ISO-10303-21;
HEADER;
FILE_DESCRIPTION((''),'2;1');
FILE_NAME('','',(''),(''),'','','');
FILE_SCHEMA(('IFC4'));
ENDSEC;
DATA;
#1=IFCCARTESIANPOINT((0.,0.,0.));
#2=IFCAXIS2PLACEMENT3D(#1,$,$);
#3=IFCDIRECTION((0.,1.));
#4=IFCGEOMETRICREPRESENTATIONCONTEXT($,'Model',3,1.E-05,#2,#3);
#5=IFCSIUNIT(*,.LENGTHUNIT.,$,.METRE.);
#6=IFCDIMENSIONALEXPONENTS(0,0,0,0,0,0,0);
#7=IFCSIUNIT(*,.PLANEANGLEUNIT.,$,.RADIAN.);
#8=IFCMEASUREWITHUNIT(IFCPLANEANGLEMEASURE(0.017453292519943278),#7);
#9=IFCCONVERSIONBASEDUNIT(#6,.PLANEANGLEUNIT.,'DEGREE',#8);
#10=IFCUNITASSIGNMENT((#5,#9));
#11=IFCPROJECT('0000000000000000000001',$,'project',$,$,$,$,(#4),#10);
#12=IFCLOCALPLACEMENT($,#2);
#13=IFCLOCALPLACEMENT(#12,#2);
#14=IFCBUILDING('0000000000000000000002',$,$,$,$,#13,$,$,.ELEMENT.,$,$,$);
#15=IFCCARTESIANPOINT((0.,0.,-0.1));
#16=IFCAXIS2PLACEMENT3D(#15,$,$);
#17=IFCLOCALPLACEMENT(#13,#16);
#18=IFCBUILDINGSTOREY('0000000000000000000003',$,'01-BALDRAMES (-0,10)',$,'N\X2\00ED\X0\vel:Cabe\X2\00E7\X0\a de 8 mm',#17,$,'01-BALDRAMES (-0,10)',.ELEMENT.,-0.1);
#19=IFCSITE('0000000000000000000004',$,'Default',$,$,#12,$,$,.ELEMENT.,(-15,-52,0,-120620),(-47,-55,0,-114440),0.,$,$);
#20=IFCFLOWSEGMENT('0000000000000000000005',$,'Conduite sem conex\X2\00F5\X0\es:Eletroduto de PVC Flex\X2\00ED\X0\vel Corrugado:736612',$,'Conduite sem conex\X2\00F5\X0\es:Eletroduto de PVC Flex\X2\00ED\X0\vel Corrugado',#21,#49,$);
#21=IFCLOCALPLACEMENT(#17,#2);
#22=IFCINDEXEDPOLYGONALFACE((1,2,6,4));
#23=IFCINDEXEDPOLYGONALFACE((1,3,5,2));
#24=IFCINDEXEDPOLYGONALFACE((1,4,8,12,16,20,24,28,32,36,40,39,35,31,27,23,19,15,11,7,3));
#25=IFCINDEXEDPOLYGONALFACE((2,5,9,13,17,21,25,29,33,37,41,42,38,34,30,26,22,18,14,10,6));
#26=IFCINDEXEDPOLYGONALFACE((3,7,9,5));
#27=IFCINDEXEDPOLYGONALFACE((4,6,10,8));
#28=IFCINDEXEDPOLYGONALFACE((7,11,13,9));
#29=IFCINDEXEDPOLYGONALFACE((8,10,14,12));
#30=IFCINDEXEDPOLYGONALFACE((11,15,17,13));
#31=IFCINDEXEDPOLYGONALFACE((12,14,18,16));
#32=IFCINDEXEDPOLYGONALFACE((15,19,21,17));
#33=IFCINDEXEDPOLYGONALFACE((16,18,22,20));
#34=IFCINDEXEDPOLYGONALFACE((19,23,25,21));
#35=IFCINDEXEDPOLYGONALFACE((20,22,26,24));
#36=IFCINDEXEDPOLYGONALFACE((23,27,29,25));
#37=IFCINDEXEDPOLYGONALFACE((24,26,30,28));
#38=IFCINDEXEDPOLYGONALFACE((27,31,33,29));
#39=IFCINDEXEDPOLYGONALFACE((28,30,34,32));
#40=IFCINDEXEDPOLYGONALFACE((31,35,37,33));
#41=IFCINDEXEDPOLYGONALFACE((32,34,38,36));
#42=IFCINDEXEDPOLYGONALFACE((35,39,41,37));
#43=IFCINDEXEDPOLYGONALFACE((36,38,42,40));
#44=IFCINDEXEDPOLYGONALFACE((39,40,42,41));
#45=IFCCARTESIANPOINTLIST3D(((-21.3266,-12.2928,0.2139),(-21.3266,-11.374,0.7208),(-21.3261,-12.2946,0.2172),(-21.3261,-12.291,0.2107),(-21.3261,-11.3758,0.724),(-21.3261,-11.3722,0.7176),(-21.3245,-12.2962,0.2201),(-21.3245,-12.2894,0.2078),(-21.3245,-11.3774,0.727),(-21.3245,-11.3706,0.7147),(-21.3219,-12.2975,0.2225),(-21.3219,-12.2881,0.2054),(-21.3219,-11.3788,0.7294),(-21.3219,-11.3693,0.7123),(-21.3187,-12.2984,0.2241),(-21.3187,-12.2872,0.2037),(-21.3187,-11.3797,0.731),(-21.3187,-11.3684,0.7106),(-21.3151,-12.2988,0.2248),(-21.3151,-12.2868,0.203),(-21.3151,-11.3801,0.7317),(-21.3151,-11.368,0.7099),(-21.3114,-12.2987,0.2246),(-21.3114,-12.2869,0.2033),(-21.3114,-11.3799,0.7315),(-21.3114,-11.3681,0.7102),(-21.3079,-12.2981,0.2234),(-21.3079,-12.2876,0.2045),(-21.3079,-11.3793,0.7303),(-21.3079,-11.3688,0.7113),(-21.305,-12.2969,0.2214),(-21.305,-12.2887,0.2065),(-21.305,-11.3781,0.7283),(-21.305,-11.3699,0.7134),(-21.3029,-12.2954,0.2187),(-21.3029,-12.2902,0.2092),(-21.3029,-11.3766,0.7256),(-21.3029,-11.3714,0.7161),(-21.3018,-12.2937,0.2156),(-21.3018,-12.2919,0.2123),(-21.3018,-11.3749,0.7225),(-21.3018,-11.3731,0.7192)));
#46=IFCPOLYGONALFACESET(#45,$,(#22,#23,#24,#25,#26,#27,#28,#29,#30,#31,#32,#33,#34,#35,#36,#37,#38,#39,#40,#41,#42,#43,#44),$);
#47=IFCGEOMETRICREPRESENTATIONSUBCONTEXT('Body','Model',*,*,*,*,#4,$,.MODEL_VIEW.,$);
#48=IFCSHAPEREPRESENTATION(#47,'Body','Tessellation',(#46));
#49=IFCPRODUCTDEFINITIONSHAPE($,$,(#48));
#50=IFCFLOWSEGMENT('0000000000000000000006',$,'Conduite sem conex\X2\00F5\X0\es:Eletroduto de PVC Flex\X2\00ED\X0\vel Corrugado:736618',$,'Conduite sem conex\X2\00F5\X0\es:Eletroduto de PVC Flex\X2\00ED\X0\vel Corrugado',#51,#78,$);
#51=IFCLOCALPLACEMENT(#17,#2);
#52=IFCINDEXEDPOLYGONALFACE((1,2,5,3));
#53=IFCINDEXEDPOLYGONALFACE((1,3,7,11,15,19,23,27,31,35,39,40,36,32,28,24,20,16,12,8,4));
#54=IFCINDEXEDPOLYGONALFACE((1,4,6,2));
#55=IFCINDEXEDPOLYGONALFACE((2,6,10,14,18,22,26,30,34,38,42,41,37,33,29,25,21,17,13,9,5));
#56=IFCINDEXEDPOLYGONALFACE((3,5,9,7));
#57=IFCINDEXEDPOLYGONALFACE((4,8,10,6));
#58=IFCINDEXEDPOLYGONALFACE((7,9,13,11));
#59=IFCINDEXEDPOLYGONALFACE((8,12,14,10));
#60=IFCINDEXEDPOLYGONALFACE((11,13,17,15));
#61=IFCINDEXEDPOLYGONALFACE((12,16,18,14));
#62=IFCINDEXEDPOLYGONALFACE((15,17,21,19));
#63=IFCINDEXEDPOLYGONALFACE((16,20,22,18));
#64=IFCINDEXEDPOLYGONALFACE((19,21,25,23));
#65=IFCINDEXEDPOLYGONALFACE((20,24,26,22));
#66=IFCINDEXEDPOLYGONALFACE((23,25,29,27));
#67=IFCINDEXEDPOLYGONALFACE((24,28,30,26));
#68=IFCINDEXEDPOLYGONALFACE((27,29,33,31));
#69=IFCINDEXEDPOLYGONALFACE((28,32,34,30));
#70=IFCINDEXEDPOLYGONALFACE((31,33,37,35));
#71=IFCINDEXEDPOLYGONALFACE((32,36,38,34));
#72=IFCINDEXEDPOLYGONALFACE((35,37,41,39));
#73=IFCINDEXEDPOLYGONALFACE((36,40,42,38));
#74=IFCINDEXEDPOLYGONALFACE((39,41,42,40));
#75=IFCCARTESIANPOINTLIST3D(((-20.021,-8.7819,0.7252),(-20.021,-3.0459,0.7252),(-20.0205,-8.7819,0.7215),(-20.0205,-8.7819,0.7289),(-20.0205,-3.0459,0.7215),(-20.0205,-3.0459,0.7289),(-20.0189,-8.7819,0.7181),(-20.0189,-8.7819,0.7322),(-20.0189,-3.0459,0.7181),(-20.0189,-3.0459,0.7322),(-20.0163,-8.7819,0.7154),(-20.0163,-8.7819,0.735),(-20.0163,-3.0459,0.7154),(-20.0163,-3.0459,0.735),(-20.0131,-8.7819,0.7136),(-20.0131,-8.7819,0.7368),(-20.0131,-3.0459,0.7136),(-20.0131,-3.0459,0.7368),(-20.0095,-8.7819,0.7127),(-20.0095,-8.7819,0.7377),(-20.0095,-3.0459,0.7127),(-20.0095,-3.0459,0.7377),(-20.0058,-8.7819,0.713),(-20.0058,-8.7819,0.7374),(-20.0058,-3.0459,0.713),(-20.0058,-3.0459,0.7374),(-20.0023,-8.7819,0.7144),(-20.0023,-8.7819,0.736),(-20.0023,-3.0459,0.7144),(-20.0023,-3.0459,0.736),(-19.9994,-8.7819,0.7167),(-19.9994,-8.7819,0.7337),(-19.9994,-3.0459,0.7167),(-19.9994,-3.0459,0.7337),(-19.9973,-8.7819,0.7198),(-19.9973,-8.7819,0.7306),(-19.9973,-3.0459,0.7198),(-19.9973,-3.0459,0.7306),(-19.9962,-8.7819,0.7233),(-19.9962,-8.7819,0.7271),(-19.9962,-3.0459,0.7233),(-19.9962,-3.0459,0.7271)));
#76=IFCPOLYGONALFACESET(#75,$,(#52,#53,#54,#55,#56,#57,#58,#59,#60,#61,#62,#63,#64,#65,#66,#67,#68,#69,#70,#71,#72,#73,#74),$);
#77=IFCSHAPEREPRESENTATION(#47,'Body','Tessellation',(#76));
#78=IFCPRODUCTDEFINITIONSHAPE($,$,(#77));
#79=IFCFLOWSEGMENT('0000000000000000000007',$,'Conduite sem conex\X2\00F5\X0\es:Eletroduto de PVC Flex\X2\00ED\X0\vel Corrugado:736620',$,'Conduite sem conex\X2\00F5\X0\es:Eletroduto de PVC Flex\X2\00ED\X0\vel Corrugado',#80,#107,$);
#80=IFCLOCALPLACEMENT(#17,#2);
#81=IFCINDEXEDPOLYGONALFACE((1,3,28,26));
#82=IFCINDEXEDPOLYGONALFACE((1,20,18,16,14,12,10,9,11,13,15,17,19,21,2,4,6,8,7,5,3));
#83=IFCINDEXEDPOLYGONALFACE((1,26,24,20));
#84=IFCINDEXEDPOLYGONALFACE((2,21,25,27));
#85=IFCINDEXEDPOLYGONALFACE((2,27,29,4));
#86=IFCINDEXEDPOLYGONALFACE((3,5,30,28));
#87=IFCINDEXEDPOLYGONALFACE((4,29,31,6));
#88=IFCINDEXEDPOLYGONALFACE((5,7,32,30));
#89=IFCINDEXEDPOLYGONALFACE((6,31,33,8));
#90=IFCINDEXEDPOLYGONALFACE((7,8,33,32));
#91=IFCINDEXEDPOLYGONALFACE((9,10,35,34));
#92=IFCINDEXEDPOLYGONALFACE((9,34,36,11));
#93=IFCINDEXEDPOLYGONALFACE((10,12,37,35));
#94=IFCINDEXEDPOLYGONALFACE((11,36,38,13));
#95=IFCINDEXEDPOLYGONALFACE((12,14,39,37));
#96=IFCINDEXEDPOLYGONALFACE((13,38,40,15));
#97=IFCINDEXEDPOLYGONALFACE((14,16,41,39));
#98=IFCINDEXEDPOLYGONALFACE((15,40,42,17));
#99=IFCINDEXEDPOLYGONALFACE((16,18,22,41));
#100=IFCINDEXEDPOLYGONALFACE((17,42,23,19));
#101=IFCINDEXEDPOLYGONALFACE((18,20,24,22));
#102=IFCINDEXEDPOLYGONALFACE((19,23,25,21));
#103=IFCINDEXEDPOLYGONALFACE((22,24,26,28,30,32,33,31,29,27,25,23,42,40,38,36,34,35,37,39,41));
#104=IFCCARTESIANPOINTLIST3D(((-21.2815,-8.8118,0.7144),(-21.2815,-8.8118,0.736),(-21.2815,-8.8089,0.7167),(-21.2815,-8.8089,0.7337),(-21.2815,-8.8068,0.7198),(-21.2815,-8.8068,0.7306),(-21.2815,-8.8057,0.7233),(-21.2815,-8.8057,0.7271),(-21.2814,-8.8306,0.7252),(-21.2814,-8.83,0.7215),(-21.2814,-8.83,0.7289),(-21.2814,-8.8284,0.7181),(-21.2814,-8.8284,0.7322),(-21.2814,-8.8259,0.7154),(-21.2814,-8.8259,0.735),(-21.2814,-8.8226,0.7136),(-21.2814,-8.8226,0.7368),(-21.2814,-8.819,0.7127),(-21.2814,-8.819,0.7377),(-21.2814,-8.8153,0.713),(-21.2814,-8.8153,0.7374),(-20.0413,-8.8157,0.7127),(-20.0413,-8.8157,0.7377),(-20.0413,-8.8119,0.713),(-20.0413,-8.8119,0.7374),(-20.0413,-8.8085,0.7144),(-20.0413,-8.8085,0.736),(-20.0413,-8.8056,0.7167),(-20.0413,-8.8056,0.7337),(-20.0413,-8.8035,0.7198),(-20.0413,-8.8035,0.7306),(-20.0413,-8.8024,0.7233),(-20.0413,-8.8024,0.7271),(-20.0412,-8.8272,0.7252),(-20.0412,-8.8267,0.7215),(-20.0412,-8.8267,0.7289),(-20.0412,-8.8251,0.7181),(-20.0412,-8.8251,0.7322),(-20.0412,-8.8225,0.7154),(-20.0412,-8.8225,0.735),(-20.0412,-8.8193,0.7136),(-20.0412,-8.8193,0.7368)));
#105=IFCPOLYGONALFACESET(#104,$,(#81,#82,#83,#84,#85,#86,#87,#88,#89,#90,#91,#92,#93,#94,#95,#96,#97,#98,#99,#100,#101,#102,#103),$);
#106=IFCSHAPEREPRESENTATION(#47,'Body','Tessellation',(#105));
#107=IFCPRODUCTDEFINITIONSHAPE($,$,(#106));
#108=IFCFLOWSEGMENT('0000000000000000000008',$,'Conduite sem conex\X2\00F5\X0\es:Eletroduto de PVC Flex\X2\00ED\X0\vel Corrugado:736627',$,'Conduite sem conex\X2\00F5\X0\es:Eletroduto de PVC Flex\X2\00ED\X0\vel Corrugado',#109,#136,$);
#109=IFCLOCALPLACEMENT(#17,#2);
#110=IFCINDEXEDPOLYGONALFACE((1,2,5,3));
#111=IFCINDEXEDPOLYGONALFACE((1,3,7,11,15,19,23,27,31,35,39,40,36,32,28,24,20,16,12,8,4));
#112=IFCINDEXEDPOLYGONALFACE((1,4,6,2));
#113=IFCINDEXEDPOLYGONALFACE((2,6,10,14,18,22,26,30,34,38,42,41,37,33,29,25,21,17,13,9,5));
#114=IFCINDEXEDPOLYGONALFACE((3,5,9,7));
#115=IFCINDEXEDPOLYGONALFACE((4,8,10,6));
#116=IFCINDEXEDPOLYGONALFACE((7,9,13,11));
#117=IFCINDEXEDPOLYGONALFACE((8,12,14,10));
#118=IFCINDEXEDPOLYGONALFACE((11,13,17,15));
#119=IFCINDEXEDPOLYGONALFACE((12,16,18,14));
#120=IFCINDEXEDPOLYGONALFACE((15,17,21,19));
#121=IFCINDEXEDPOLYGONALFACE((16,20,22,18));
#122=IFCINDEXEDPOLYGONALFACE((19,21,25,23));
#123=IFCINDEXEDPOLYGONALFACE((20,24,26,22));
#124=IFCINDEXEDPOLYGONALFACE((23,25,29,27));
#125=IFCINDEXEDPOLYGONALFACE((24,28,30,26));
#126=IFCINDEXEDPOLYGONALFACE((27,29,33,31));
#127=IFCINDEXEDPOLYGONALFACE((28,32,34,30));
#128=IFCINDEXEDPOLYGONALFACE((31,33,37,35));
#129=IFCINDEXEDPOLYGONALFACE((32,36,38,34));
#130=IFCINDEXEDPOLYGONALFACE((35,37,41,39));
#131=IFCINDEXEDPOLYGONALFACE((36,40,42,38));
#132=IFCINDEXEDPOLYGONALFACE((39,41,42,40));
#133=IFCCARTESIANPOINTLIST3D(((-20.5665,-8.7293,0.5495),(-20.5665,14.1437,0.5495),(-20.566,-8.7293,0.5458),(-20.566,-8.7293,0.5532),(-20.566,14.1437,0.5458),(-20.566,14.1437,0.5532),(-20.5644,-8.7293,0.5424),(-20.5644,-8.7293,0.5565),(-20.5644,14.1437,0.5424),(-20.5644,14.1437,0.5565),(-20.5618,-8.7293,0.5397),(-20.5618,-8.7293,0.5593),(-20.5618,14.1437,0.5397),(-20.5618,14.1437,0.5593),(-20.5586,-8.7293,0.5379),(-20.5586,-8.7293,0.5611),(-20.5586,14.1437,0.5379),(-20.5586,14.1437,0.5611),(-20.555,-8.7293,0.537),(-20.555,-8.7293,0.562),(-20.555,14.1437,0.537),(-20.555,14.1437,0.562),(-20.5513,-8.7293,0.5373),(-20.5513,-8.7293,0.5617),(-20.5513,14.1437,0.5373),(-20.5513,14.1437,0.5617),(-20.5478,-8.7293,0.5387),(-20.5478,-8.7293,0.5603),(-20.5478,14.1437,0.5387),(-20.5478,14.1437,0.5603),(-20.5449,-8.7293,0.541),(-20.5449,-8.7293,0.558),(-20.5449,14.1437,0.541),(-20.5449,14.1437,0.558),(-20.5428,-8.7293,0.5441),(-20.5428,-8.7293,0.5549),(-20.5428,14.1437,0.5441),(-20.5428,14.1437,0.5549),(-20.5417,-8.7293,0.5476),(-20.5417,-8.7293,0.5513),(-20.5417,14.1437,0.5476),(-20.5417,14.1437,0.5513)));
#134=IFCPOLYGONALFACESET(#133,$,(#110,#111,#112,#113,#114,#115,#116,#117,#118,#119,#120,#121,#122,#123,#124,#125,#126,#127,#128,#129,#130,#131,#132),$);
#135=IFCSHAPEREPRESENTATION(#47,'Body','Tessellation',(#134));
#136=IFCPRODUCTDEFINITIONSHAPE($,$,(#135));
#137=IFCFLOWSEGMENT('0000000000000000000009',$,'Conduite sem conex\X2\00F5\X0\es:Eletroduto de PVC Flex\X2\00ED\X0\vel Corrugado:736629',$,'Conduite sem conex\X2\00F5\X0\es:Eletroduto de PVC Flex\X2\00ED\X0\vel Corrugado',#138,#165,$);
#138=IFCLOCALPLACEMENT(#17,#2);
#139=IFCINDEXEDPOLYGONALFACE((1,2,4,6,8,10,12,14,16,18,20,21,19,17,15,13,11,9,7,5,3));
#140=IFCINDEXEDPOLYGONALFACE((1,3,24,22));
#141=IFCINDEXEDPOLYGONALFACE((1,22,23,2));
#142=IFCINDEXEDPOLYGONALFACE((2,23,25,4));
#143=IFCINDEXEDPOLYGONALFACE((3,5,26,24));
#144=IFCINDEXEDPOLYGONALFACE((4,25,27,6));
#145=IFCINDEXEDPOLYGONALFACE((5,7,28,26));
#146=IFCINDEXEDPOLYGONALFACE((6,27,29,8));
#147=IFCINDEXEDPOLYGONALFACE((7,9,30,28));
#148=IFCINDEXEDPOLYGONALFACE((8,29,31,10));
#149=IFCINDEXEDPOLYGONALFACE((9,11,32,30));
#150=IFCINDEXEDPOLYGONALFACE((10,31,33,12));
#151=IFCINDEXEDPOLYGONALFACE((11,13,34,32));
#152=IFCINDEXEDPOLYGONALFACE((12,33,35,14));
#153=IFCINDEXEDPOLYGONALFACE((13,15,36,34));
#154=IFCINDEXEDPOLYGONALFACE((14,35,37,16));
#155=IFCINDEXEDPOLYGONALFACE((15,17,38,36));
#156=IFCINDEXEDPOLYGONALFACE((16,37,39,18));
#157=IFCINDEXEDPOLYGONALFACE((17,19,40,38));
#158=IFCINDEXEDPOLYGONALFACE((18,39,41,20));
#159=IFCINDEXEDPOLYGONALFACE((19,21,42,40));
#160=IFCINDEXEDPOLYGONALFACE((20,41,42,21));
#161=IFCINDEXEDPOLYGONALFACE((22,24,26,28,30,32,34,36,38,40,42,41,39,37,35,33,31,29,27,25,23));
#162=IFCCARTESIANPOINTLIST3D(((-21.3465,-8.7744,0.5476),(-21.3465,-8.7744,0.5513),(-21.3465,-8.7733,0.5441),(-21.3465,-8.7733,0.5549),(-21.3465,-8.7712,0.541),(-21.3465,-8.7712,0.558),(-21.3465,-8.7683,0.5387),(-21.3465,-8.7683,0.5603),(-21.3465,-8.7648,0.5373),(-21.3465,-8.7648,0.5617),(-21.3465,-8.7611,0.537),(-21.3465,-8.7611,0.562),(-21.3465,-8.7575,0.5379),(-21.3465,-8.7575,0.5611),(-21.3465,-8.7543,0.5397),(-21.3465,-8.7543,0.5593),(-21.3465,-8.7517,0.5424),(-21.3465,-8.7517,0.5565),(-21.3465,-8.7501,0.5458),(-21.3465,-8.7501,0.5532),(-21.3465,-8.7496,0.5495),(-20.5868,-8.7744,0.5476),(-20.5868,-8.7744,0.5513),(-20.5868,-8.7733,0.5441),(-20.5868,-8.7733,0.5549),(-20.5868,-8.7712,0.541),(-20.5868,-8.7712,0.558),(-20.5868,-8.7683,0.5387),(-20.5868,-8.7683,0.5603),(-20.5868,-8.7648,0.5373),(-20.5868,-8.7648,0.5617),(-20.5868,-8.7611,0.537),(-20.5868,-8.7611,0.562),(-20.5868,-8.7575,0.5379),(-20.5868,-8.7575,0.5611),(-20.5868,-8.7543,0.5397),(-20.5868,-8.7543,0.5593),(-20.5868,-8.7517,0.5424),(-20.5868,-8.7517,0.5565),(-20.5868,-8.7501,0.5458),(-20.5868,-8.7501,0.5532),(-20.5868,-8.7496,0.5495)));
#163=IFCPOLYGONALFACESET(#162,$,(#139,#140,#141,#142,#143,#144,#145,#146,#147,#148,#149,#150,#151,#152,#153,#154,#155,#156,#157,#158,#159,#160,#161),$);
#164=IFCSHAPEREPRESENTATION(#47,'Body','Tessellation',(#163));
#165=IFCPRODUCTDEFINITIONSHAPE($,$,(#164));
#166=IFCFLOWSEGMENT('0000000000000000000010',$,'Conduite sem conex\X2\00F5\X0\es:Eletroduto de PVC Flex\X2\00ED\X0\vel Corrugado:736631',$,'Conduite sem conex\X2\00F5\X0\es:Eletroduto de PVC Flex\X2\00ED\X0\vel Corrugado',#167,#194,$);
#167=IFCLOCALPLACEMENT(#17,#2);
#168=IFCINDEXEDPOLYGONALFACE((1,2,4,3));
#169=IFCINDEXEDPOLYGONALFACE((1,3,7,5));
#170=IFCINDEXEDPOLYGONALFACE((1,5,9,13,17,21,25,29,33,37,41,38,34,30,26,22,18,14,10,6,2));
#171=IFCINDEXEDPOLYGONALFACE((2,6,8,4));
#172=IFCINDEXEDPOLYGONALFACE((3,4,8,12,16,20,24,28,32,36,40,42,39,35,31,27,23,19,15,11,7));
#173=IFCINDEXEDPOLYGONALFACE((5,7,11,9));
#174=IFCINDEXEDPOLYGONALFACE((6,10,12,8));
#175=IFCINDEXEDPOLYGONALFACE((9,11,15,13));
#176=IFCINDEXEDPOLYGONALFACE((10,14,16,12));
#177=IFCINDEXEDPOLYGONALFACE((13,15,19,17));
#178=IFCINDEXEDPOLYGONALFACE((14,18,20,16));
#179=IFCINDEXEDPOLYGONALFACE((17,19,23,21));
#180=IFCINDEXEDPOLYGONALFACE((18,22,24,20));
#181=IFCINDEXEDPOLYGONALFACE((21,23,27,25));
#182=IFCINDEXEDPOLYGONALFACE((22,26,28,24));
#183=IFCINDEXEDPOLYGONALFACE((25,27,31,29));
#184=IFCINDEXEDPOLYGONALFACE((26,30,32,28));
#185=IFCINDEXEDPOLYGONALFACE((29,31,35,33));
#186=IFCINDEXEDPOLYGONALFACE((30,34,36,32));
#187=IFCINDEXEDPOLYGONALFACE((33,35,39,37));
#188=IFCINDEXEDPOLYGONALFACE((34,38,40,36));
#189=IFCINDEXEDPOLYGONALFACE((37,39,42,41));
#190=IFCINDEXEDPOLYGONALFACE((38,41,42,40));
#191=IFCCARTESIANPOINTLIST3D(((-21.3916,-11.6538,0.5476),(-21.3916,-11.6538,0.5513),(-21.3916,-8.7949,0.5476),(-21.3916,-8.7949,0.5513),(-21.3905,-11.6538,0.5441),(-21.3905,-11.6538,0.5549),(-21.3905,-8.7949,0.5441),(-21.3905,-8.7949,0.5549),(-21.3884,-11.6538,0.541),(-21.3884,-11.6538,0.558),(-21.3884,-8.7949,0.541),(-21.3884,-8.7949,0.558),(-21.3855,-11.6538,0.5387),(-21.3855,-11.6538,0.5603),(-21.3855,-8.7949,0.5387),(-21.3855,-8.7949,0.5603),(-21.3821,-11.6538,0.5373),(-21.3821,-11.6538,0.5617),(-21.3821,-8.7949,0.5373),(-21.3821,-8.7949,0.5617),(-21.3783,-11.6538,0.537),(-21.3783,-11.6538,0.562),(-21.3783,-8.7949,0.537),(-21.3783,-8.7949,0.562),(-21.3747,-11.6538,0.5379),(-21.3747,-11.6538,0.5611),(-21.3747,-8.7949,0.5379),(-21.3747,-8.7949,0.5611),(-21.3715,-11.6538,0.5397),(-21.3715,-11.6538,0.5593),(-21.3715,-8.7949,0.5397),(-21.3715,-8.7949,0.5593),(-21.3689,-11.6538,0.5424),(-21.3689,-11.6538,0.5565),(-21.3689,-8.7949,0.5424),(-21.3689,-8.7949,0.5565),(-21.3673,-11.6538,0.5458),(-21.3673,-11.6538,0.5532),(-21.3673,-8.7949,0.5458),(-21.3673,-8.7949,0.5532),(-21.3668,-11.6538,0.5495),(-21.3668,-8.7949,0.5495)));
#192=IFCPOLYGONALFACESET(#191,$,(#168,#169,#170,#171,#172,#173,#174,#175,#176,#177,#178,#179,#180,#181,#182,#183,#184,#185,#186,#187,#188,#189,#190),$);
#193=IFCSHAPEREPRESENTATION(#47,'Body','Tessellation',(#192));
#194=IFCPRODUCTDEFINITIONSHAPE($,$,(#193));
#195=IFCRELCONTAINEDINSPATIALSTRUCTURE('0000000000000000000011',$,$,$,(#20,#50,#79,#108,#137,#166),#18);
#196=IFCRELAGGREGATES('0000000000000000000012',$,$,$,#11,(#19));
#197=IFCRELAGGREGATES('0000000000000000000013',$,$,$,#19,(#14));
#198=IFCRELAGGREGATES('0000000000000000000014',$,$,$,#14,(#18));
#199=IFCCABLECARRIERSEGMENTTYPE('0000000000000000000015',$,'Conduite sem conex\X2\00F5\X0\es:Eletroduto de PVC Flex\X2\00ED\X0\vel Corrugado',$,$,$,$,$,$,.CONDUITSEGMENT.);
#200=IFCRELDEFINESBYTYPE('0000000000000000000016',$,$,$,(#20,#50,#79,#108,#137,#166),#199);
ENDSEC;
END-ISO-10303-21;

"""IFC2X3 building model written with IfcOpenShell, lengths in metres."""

from ifc_helpers import new_model, entity, si_unit, converted_unit, direction, frame, frame_2d, origin, origin_2d_with_axis, place, context, subcontext, project, spatial, circle, extrude, type_object, element, save


model = new_model("IFC2X3")

# Units and contexts
model_context = context("Model", 3, precision=1e-05, world=origin(), true_north=direction((0.0, 1.0)))
body_context = subcontext(model_context, "Body", "Model", "MODEL_VIEW")
ifc_project = project(units=[si_unit("LENGTHUNIT", "METRE"), converted_unit("PLANEANGLEUNIT", "DEGREE", entity("IfcPlaneAngleMeasure", 0.017453292519943278), si_unit("PLANEANGLEUNIT", "RADIAN"), dimensions=[0, 0, 0, 0, 0, 0, 0])], contexts=[model_context])

# Site, building, storey
site_placement = place(None, origin())
site = spatial("IfcSite", under=ifc_project, at=site_placement, Name="Default", CompositionType="ELEMENT", RefLatitude=(-15, -52, 0, -120620), RefLongitude=(-47, -55, 0, -114440), RefElevation=0.0)
building_placement = place(site_placement, origin())
building = spatial("IfcBuilding", under=site, at=building_placement, CompositionType="ELEMENT")
storey_placement = place(building_placement, frame((0.0, 0.0, -0.1)))
storey = spatial("IfcBuildingStorey", under=building, at=storey_placement, Name="01-BALDRAMES (-0,10)", ObjectType="Nível:Cabeça de 8 mm", LongName="01-BALDRAMES (-0,10)", CompositionType="ELEMENT", Elevation=-0.1)

# Flow segments
cable_carrier_segment_type = type_object("IfcCableCarrierSegmentType", Name="Conduite sem conexões:Eletroduto de PVC Flexível Corrugado", PredefinedType="CONDUITSEGMENT")
flow_segment_1_placement = place(storey_placement, origin())
element("IfcFlowSegment", 1, at=flow_segment_1_placement, inside=storey, type_object=cable_carrier_segment_type, Name="Conduite sem conexões:Eletroduto de PVC Flexível Corrugado:736612", ObjectType="Conduite sem conexões:Eletroduto de PVC Flexível Corrugado", context=body_context, shape_type="SweptSolid", body=[
    extrude(circle(Radius=0.0125, at=frame_2d((0.0, 0.0), x_axis=(1.0, 0.0))), frame((-21.3141, -12.2928, 0.2139), z_axis=(0.0, 0.87559, 0.483055), x_axis=(-1.0, 0.0, 0.0)), (0.0, 0.0, 1.0), 1.0493),
])
flow_segment_2_placement = place(storey_placement, origin())
element("IfcFlowSegment", 2, at=flow_segment_2_placement, inside=storey, type_object=cable_carrier_segment_type, Name="Conduite sem conexões:Eletroduto de PVC Flexível Corrugado:736618", ObjectType="Conduite sem conexões:Eletroduto de PVC Flexível Corrugado", context=body_context, shape_type="SweptSolid", body=[
    extrude(circle(Radius=0.0125, at=frame_2d((0.0, 0.0), x_axis=(1.0, 0.0))), frame((-20.0085, -8.7819, 0.7252), z_axis=(0.0, 1.0, 0.0), x_axis=(-1.0, 0.0, 0.0)), (0.0, 0.0, 1.0), 5.736),
])
flow_segment_3_placement = place(storey_placement, origin())
element("IfcFlowSegment", 3, at=flow_segment_3_placement, inside=storey, type_object=cable_carrier_segment_type, Name="Conduite sem conexões:Eletroduto de PVC Flexível Corrugado:736620", ObjectType="Conduite sem conexões:Eletroduto de PVC Flexível Corrugado", context=body_context, shape_type="SweptSolid", body=[
    extrude(circle(Radius=0.0125, at=origin_2d_with_axis()), frame((-21.2814, -8.8181, 0.7252), z_axis=(0.999996, 0.002692, 0.0), x_axis=(0.002692, -0.999996, 0.0)), (0.0, 0.0, 1.0), 1.2402),
])
flow_segment_4_placement = place(storey_placement, origin())
element("IfcFlowSegment", 4, at=flow_segment_4_placement, inside=storey, type_object=cable_carrier_segment_type, Name="Conduite sem conexões:Eletroduto de PVC Flexível Corrugado:736627", ObjectType="Conduite sem conexões:Eletroduto de PVC Flexível Corrugado", context=body_context, shape_type="SweptSolid", body=[
    extrude(circle(Radius=0.0125, at=origin_2d_with_axis()), frame((-20.554, -8.7293, 0.5495), z_axis=(0.0, 1.0, 0.0), x_axis=(-1.0, 0.0, 0.0)), (0.0, 0.0, 1.0), 22.873),
])
flow_segment_5_placement = place(storey_placement, origin())
element("IfcFlowSegment", 5, at=flow_segment_5_placement, inside=storey, type_object=cable_carrier_segment_type, Name="Conduite sem conexões:Eletroduto de PVC Flexível Corrugado:736629", ObjectType="Conduite sem conexões:Eletroduto de PVC Flexível Corrugado", context=body_context, shape_type="SweptSolid", body=[
    extrude(circle(Radius=0.0125, at=frame_2d((0.0, 0.0), x_axis=(1.0, 0.0))), frame((-21.3465, -8.7621, 0.5495), z_axis=(1.0, 0.0, 0.0), x_axis=(0.0, 1.0, 0.0)), (0.0, 0.0, 1.0), 0.7596),
])
flow_segment_6_placement = place(storey_placement, origin())
element("IfcFlowSegment", 6, at=flow_segment_6_placement, inside=storey, type_object=cable_carrier_segment_type, Name="Conduite sem conexões:Eletroduto de PVC Flexível Corrugado:736631", ObjectType="Conduite sem conexões:Eletroduto de PVC Flexível Corrugado", context=body_context, shape_type="SweptSolid", body=[
    extrude(circle(Radius=0.0125, at=origin_2d_with_axis()), frame((-21.3793, -11.6538, 0.5495), z_axis=(0.0, 1.0, 0.0), x_axis=(1.0, 0.0, 0.0)), (0.0, 0.0, 1.0), 2.8589),
])

save(model, "model.ifc")
